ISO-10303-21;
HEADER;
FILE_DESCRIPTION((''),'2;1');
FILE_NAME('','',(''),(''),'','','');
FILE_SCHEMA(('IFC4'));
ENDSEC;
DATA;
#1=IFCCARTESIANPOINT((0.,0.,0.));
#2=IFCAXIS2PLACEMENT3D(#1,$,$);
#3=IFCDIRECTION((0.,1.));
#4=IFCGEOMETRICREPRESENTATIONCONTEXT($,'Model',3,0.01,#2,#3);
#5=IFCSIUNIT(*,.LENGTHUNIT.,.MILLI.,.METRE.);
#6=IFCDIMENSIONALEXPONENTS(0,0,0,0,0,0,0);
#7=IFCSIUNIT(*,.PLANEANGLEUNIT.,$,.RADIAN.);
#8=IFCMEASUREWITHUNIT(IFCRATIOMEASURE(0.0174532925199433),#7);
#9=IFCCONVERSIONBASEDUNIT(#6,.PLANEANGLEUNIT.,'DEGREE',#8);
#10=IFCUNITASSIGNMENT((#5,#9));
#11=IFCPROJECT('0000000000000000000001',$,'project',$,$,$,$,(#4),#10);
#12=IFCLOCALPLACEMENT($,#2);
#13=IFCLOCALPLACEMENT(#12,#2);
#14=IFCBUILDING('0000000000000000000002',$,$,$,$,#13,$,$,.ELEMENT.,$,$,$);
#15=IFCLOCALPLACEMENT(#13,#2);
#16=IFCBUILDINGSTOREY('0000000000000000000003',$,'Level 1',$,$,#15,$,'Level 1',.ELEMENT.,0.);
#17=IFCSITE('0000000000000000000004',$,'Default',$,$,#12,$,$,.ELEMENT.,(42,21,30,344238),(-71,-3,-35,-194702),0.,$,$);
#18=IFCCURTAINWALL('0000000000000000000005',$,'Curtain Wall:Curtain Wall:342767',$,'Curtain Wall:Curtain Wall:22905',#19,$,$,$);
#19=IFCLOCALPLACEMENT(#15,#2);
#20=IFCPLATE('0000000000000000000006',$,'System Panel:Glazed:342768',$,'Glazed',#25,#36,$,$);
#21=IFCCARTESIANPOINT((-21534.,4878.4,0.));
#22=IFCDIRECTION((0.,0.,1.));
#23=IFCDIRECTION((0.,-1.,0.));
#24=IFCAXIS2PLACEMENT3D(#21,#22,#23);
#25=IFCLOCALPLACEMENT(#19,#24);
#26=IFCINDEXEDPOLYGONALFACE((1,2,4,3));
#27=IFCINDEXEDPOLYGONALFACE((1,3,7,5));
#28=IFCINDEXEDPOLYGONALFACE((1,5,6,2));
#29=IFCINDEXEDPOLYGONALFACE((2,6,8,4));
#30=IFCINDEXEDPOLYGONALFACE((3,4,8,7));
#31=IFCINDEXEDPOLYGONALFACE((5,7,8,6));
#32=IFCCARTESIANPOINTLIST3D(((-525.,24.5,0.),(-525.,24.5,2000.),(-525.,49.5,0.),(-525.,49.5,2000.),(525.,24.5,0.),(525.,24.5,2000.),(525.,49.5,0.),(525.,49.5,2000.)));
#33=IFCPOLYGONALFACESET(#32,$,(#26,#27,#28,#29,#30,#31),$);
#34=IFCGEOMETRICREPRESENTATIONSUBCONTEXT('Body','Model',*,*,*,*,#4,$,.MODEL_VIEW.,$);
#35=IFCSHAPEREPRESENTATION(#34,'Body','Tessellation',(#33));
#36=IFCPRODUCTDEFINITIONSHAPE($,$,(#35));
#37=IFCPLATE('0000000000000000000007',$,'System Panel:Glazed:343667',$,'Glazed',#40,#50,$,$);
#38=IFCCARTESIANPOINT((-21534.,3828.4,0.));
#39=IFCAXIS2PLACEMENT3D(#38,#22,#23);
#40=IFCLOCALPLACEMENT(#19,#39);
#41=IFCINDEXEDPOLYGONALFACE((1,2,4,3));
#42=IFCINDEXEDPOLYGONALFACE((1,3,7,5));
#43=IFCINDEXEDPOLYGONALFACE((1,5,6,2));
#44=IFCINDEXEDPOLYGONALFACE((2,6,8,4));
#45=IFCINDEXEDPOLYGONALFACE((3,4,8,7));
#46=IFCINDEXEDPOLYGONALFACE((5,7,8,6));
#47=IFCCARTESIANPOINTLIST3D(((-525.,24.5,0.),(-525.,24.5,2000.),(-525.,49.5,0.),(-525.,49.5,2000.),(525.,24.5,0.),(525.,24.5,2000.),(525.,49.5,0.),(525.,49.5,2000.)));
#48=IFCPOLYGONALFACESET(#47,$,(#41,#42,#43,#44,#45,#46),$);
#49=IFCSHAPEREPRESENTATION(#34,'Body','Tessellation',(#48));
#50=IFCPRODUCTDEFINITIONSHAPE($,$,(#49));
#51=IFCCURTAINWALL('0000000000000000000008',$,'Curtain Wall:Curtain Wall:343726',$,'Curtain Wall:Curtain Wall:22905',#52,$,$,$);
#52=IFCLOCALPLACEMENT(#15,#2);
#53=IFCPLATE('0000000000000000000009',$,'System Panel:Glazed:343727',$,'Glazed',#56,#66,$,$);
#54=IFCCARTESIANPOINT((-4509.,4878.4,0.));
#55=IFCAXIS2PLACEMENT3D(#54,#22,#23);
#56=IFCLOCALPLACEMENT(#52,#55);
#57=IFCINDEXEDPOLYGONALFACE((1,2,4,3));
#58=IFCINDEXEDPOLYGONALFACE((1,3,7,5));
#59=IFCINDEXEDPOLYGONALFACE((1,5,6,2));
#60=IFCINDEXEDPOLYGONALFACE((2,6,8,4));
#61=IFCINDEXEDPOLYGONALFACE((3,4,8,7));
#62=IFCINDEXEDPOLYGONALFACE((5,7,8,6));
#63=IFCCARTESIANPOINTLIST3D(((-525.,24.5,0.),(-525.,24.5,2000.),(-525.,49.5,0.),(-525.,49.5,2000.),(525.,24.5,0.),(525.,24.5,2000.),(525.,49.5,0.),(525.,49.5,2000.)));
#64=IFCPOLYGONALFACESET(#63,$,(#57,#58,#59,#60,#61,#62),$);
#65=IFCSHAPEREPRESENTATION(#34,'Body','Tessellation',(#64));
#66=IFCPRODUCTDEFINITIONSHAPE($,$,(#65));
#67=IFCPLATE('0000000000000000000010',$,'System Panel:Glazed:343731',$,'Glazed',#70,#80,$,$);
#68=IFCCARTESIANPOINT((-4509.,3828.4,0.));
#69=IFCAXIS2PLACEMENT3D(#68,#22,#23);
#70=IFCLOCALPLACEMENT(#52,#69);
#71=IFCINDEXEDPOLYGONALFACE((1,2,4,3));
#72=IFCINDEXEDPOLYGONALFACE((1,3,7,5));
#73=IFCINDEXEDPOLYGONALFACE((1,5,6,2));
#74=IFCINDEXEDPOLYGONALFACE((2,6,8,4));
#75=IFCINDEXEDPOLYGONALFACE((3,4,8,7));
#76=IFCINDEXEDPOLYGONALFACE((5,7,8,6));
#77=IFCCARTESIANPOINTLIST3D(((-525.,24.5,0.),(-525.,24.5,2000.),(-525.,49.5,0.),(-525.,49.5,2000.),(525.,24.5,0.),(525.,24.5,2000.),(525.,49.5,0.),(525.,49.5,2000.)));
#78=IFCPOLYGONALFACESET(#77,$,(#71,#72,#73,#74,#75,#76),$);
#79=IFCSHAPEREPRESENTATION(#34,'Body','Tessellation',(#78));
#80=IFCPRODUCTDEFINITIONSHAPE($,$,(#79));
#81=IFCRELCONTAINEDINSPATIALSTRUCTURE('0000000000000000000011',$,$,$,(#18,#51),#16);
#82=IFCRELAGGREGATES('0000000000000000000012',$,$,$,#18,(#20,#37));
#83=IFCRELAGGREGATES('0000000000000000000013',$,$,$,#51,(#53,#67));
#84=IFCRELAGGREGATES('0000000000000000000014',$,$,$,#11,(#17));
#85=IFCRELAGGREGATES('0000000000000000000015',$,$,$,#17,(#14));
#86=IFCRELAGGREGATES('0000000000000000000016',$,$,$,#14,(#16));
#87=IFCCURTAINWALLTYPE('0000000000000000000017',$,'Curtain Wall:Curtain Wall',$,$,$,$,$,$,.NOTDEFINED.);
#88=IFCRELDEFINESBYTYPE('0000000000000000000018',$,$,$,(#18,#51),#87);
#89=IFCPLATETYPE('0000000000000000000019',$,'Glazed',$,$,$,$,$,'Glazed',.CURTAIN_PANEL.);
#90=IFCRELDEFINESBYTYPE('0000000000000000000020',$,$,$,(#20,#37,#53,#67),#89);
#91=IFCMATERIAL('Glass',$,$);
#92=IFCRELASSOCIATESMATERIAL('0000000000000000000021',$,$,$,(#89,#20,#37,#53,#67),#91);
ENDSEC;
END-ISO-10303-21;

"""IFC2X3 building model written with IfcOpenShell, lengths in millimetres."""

from ifc_helpers import new_model, entity, si_unit, converted_unit, direction, frame, origin, origin_2d_with_axis, place, context, subcontext, project, spatial, rectangle, extrude, source, transform, mapped, material, type_object, type_shapes, element, aggregate, save


model = new_model("IFC2X3")

# Units and contexts
model_context = context("Model", 3, precision=0.01, world=origin(), true_north=direction((0.0, 1.0)))
body_context = subcontext(model_context, "Body", "Model", "MODEL_VIEW")
ifc_project = project(units=[si_unit("LENGTHUNIT", "METRE", prefix="MILLI"), converted_unit("PLANEANGLEUNIT", "DEGREE", entity("IfcRatioMeasure", 0.0174532925199433), si_unit("PLANEANGLEUNIT", "RADIAN"), dimensions=[0, 0, 0, 0, 0, 0, 0])], contexts=[model_context])

# Site, building, storey
site_placement = place(None, origin())
site = spatial("IfcSite", under=ifc_project, at=site_placement, Name="Default", CompositionType="ELEMENT", RefLatitude=(42, 21, 30, 344238), RefLongitude=(-71, -3, -35, -194702), RefElevation=0.0)
building_placement = place(site_placement, origin())
building = spatial("IfcBuilding", under=site, at=building_placement, CompositionType="ELEMENT")
storey_placement = place(building_placement, origin())
storey = spatial("IfcBuildingStorey", under=building, at=storey_placement, Name="Level 1", LongName="Level 1", CompositionType="ELEMENT", Elevation=0.0)

# Curtain walls, plates
curtain_wall_type = type_object("IfcCurtainWallType", Name="Curtain Wall:Curtain Wall", PredefinedType="NOTDEFINED")
curtain_wall_1_placement = place(storey_placement, origin())
curtain_wall_1 = element("IfcCurtainWall", 1, at=curtain_wall_1_placement, inside=storey, type_object=curtain_wall_type, Name="Curtain Wall:Curtain Wall:342767", ObjectType="Curtain Wall:Curtain Wall:22905")
ifc_material_1 = material(Name="Glass")
plate_type_1 = type_object("IfcPlateType", Name="Glazed", ElementType="Glazed", PredefinedType="CURTAIN_PANEL", material=ifc_material_1)
shared_shape_1 = source(origin(), body_context, "Body", "SweptSolid", [
    extrude(rectangle(XDim=25.0, YDim=1050.0, at=origin_2d_with_axis()), frame((0.0, 37.0, 0.0), z_axis=(0.0, 0.0, 1.0), x_axis=(0.0, 1.0, 0.0)), (0.0, 0.0, 1.0), 2000.0),
])
type_shapes(plate_type_1, [shared_shape_1])
plate_1_placement = place(curtain_wall_1_placement, frame((-21534.0, 4878.4, 0.0), z_axis=(0.0, 0.0, 1.0), x_axis=(0.0, -1.0, 0.0)))
plate_1 = element("IfcPlate", 2, at=plate_1_placement, type_object=plate_type_1, material=ifc_material_1, Name="System Panel:Glazed:342768", ObjectType="Glazed", context=body_context, shape_type="MappedRepresentation", body=[
    mapped(shared_shape_1, transform((0.0, 0.0, 0.0), scale=1.0)),
])
plate_2_placement = place(curtain_wall_1_placement, frame((-21534.0, 3828.4, 0.0), z_axis=(0.0, 0.0, 1.0), x_axis=(0.0, -1.0, 0.0)))
plate_2 = element("IfcPlate", 3, at=plate_2_placement, type_object=plate_type_1, material=ifc_material_1, Name="System Panel:Glazed:343667", ObjectType="Glazed", context=body_context, shape_type="MappedRepresentation", body=[
    mapped(shared_shape_1, transform((0.0, 0.0, 0.0), scale=1.0)),
])
curtain_wall_2_placement = place(storey_placement, origin())
curtain_wall_2 = element("IfcCurtainWall", 4, at=curtain_wall_2_placement, inside=storey, type_object=curtain_wall_type, Name="Curtain Wall:Curtain Wall:343726", ObjectType="Curtain Wall:Curtain Wall:22905")
plate_3_placement = place(curtain_wall_2_placement, frame((-4509.0, 4878.4, 0.0), z_axis=(0.0, 0.0, 1.0), x_axis=(0.0, -1.0, 0.0)))
plate_3 = element("IfcPlate", 5, at=plate_3_placement, type_object=plate_type_1, material=ifc_material_1, Name="System Panel:Glazed:343727", ObjectType="Glazed", context=body_context, shape_type="MappedRepresentation", body=[
    mapped(shared_shape_1, transform((0.0, 0.0, 0.0), scale=1.0)),
])
plate_4_placement = place(curtain_wall_2_placement, frame((-4509.0, 3828.4, 0.0), z_axis=(0.0, 0.0, 1.0), x_axis=(0.0, -1.0, 0.0)))
plate_4 = element("IfcPlate", 6, at=plate_4_placement, type_object=plate_type_1, material=ifc_material_1, Name="System Panel:Glazed:343731", ObjectType="Glazed", context=body_context, shape_type="MappedRepresentation", body=[
    mapped(shared_shape_1, transform((0.0, 0.0, 0.0), scale=1.0)),
])

aggregate(curtain_wall_1, [plate_1, plate_2])
aggregate(curtain_wall_2, [plate_3, plate_4])

save(model, "model.ifc")
